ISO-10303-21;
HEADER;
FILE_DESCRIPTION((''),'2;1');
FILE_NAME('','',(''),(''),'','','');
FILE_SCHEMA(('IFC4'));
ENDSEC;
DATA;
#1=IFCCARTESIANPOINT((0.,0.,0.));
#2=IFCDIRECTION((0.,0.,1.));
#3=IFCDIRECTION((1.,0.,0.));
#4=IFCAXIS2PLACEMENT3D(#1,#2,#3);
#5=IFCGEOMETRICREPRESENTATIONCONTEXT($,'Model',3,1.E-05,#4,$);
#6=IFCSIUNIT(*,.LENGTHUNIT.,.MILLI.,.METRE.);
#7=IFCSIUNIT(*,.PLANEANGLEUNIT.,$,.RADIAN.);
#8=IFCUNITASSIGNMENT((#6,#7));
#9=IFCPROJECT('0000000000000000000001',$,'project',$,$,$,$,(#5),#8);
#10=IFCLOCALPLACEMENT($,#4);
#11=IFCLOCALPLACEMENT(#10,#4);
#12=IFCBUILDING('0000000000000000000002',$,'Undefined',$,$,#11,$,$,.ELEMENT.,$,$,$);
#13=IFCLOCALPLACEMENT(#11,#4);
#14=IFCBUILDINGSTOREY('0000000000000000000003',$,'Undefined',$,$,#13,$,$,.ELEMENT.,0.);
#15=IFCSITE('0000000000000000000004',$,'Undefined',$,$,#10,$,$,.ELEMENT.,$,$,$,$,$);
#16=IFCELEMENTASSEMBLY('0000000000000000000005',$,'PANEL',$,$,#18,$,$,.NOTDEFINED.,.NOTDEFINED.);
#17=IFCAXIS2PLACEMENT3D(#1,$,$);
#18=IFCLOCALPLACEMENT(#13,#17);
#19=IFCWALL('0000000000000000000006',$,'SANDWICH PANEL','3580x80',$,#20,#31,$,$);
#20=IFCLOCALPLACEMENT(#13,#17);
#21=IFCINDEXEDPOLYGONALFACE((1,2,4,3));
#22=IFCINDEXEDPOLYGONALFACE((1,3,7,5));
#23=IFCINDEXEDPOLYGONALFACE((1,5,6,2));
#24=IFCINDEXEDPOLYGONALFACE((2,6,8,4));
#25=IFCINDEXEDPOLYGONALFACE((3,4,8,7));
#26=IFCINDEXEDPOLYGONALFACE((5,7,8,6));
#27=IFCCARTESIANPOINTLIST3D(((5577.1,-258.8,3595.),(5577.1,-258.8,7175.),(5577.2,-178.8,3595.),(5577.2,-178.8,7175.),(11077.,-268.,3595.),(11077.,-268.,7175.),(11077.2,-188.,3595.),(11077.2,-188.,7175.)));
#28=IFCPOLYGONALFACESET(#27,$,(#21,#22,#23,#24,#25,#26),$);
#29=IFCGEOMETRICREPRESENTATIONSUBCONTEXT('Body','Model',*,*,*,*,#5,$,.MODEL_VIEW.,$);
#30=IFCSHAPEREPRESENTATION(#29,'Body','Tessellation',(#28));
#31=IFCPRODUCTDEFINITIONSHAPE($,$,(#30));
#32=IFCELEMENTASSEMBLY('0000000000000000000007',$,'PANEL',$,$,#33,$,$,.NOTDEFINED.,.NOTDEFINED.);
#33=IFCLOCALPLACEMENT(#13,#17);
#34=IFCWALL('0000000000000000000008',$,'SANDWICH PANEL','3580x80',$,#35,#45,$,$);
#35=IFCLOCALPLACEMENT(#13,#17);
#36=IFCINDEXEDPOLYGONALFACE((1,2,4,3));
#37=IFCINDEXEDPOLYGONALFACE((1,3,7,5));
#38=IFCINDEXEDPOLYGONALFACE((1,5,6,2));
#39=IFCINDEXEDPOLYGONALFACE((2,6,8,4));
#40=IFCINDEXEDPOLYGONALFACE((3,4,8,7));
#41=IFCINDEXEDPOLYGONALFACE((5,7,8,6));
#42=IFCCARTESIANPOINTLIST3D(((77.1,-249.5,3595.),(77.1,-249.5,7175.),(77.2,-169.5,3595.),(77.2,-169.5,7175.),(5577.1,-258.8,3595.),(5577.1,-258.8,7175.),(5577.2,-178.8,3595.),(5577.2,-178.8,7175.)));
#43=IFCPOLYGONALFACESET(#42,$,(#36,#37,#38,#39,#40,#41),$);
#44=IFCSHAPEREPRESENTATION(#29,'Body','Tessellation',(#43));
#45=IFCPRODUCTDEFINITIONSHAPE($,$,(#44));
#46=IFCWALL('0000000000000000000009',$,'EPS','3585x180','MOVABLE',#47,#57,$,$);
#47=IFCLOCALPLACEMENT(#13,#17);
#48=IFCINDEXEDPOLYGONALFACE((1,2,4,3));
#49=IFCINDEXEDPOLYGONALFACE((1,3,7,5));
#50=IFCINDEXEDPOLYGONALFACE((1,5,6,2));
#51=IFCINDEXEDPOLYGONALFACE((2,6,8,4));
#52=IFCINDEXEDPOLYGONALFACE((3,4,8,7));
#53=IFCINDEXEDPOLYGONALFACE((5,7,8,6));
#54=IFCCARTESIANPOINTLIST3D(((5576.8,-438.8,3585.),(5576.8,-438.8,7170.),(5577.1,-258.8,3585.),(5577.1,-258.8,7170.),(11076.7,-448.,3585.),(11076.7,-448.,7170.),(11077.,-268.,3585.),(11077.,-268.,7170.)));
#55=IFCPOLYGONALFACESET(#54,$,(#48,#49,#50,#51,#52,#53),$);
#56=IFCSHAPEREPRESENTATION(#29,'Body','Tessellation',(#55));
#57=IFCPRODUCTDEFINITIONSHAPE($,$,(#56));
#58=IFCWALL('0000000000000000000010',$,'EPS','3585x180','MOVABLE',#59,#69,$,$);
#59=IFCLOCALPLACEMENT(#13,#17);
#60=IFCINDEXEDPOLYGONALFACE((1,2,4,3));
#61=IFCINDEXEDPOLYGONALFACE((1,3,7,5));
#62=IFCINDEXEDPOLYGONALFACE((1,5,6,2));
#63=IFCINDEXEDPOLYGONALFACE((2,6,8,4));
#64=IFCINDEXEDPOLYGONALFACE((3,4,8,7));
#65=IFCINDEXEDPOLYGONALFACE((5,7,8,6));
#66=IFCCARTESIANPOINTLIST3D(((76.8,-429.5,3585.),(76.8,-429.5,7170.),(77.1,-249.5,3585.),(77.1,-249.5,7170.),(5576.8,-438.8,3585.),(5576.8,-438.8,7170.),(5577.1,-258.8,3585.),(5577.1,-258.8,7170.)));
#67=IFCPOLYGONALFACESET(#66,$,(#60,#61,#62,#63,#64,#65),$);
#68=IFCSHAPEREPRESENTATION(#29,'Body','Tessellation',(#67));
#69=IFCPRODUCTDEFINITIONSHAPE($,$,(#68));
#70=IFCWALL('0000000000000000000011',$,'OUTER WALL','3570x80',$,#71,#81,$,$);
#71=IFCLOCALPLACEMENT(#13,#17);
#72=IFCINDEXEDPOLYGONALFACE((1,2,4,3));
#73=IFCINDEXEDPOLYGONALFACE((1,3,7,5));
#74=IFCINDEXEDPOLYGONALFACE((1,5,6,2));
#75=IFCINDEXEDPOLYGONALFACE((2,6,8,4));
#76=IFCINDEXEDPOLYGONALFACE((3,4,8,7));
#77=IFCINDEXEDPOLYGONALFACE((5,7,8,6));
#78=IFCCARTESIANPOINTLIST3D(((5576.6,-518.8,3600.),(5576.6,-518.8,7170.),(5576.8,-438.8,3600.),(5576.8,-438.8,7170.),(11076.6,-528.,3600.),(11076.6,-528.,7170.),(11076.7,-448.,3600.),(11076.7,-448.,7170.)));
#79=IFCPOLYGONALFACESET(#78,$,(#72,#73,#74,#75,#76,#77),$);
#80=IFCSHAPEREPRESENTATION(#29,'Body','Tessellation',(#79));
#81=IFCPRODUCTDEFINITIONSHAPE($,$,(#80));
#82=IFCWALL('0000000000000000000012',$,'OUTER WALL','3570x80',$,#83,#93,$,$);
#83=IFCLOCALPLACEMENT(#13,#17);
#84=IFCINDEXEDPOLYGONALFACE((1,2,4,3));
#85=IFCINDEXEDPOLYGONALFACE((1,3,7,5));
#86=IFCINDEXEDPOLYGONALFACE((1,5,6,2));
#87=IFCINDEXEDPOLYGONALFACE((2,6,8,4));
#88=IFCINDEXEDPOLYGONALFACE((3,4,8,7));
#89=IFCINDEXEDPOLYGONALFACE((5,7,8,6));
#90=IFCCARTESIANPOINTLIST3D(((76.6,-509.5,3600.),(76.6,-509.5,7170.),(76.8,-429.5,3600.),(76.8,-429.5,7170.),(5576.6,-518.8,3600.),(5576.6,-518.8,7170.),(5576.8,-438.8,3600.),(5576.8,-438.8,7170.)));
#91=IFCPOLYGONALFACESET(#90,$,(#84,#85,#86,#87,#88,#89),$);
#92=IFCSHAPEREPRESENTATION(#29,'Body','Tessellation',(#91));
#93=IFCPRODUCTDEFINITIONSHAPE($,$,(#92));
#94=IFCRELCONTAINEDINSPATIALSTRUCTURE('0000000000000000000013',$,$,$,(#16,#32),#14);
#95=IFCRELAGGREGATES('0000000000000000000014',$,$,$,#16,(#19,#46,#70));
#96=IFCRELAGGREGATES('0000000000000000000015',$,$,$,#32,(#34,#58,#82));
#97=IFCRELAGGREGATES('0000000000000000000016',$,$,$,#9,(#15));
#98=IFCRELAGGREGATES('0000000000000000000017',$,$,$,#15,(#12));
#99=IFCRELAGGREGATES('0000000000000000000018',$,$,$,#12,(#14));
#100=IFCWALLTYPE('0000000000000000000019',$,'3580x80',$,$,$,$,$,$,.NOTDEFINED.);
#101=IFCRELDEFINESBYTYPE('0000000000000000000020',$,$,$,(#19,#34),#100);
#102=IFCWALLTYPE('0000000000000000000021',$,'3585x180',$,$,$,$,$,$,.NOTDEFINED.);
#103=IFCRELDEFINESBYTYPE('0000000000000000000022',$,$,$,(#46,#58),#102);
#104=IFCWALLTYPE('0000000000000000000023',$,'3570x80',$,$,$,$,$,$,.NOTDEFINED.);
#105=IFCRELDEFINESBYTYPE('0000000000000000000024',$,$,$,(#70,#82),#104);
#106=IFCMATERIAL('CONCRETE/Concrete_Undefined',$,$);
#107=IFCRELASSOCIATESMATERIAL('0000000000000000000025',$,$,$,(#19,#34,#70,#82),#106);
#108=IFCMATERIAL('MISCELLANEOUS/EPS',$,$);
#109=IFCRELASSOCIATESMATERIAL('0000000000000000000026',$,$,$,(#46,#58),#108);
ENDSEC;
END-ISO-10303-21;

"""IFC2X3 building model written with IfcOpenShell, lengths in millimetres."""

from ifc_helpers import new_model, si_unit, frame, frame_2d, origin_with_axes, place, context, subcontext, project, spatial, rectangle, extrude, material, type_object, element, aggregate, save


model = new_model("IFC2X3")

# Units and contexts
model_context = context("Model", 3, precision=1e-05, world=origin_with_axes())
body_context = subcontext(model_context, "Body", "Model", "MODEL_VIEW")
ifc_project = project(units=[si_unit("LENGTHUNIT", "METRE", prefix="MILLI"), si_unit("PLANEANGLEUNIT", "RADIAN")], contexts=[model_context])

# Site, building, storey
site_placement = place(None, origin_with_axes())
site = spatial("IfcSite", under=ifc_project, at=site_placement, Name="Undefined", CompositionType="ELEMENT")
building_placement = place(site_placement, origin_with_axes())
building = spatial("IfcBuilding", under=site, at=building_placement, Name="Undefined", CompositionType="ELEMENT")
storey_placement = place(building_placement, origin_with_axes())
storey = spatial("IfcBuildingStorey", under=building, at=storey_placement, Name="Undefined", CompositionType="ELEMENT", Elevation=0.0)

# Shared definitions
ifc_material_1 = material(Name="CONCRETE/Concrete_Undefined")

# Element assemblies, walls
assembly_1_placement = place(storey_placement, origin_with_axes())
assembly_1 = element("IfcElementAssembly", 1, at=assembly_1_placement, inside=storey, Name="PANEL", AssemblyPlace="NOTDEFINED", PredefinedType="NOTDEFINED")
wall_type_1 = type_object("IfcWallType", Name="3580x80", PredefinedType="NOTDEFINED")
wall_1_placement = place(assembly_1_placement, frame((5577.1, -218.8, 3595.0), z_axis=(0.0, 0.0, 1.0), x_axis=(0.999999, -0.001684, 0.0)))
wall_1 = element("IfcWall", 2, at=wall_1_placement, type_object=wall_type_1, material=ifc_material_1, Name="SANDWICH PANEL", Description="3580x80", context=body_context, shape_type="SweptSolid", body=[
    extrude(rectangle(XDim=5500.0, YDim=80.0, at=frame_2d((0.0, 2750.0), x_axis=(0.0, -1.0))), frame((0.0, 0.0, 0.0), z_axis=(0.0, 0.0, 1.0), x_axis=(0.0, -1.0, 0.0)), (0.0, 0.0, 1.0), 3580.0),
])
assembly_2_placement = place(storey_placement, origin_with_axes())
assembly_2 = element("IfcElementAssembly", 3, at=assembly_2_placement, inside=storey, Name="PANEL", AssemblyPlace="NOTDEFINED", PredefinedType="NOTDEFINED")
wall_2_placement = place(assembly_2_placement, frame((77.1, -209.5, 3595.0), z_axis=(0.0, 0.0, 1.0), x_axis=(0.999999, -0.001684, 0.0)))
wall_2 = element("IfcWall", 4, at=wall_2_placement, type_object=wall_type_1, material=ifc_material_1, Name="SANDWICH PANEL", Description="3580x80", context=body_context, shape_type="SweptSolid", body=[
    extrude(rectangle(XDim=5500.0, YDim=80.0, at=frame_2d((0.0, 2750.0), x_axis=(0.0, -1.0))), frame((0.0, 0.0, 0.0), z_axis=(0.0, 0.0, 1.0), x_axis=(0.0, -1.0, 0.0)), (0.0, 0.0, 1.0), 3580.0),
])

# Walls
ifc_material_2 = material(Name="MISCELLANEOUS/EPS")
wall_type_2 = type_object("IfcWallType", Name="3585x180", PredefinedType="NOTDEFINED")
wall_3_placement = place(assembly_1_placement, frame((5576.9, -348.8, 3585.0), z_axis=(0.0, 0.0, 1.0), x_axis=(0.999999, -0.001684, 0.0)))
wall_3 = element("IfcWall", 5, at=wall_3_placement, type_object=wall_type_2, material=ifc_material_2, Name="EPS", Description="3585x180", ObjectType="MOVABLE", context=body_context, shape_type="SweptSolid", body=[
    extrude(rectangle(XDim=5500.0, YDim=180.0, at=frame_2d((0.0, 2750.0), x_axis=(0.0, -1.0))), frame((0.0, 0.0, 0.0), z_axis=(0.0, 0.0, 1.0), x_axis=(0.0, -1.0, 0.0)), (0.0, 0.0, 1.0), 3585.0),
])
wall_4_placement = place(assembly_2_placement, frame((76.9, -339.5, 3585.0), z_axis=(0.0, 0.0, 1.0), x_axis=(0.999999, -0.001684, 0.0)))
wall_4 = element("IfcWall", 6, at=wall_4_placement, type_object=wall_type_2, material=ifc_material_2, Name="EPS", Description="3585x180", ObjectType="MOVABLE", context=body_context, shape_type="SweptSolid", body=[
    extrude(rectangle(XDim=5500.0, YDim=180.0, at=frame_2d((0.0, 2750.0), x_axis=(0.0, -1.0))), frame((0.0, 0.0, 0.0), z_axis=(0.0, 0.0, 1.0), x_axis=(0.0, -1.0, 0.0)), (0.0, 0.0, 1.0), 3585.0),
])
wall_type_3 = type_object("IfcWallType", Name="3570x80", PredefinedType="NOTDEFINED")
wall_5_placement = place(assembly_1_placement, frame((5576.7, -478.8, 3600.0), z_axis=(0.0, 0.0, 1.0), x_axis=(0.999999, -0.001684, 0.0)))
wall_5 = element("IfcWall", 7, at=wall_5_placement, type_object=wall_type_3, material=ifc_material_1, Name="OUTER WALL", Description="3570x80", context=body_context, shape_type="SweptSolid", body=[
    extrude(rectangle(XDim=5500.0, YDim=80.0, at=frame_2d((0.0, 2750.0), x_axis=(0.0, -1.0))), frame((0.0, 0.0, 0.0), z_axis=(0.0, 0.0, 1.0), x_axis=(0.0, -1.0, 0.0)), (0.0, 0.0, 1.0), 3570.0),
])
aggregate(assembly_1, [wall_1, wall_3, wall_5])
wall_6_placement = place(assembly_2_placement, frame((76.7, -469.5, 3600.0), z_axis=(0.0, 0.0, 1.0), x_axis=(0.999999, -0.001684, 0.0)))
wall_6 = element("IfcWall", 8, at=wall_6_placement, type_object=wall_type_3, material=ifc_material_1, Name="OUTER WALL", Description="3570x80", context=body_context, shape_type="SweptSolid", body=[
    extrude(rectangle(XDim=5500.0, YDim=80.0, at=frame_2d((0.0, 2750.0), x_axis=(0.0, -1.0))), frame((0.0, 0.0, 0.0), z_axis=(0.0, 0.0, 1.0), x_axis=(0.0, -1.0, 0.0)), (0.0, 0.0, 1.0), 3570.0),
])
aggregate(assembly_2, [wall_2, wall_4, wall_6])

save(model, "model.ifc")
